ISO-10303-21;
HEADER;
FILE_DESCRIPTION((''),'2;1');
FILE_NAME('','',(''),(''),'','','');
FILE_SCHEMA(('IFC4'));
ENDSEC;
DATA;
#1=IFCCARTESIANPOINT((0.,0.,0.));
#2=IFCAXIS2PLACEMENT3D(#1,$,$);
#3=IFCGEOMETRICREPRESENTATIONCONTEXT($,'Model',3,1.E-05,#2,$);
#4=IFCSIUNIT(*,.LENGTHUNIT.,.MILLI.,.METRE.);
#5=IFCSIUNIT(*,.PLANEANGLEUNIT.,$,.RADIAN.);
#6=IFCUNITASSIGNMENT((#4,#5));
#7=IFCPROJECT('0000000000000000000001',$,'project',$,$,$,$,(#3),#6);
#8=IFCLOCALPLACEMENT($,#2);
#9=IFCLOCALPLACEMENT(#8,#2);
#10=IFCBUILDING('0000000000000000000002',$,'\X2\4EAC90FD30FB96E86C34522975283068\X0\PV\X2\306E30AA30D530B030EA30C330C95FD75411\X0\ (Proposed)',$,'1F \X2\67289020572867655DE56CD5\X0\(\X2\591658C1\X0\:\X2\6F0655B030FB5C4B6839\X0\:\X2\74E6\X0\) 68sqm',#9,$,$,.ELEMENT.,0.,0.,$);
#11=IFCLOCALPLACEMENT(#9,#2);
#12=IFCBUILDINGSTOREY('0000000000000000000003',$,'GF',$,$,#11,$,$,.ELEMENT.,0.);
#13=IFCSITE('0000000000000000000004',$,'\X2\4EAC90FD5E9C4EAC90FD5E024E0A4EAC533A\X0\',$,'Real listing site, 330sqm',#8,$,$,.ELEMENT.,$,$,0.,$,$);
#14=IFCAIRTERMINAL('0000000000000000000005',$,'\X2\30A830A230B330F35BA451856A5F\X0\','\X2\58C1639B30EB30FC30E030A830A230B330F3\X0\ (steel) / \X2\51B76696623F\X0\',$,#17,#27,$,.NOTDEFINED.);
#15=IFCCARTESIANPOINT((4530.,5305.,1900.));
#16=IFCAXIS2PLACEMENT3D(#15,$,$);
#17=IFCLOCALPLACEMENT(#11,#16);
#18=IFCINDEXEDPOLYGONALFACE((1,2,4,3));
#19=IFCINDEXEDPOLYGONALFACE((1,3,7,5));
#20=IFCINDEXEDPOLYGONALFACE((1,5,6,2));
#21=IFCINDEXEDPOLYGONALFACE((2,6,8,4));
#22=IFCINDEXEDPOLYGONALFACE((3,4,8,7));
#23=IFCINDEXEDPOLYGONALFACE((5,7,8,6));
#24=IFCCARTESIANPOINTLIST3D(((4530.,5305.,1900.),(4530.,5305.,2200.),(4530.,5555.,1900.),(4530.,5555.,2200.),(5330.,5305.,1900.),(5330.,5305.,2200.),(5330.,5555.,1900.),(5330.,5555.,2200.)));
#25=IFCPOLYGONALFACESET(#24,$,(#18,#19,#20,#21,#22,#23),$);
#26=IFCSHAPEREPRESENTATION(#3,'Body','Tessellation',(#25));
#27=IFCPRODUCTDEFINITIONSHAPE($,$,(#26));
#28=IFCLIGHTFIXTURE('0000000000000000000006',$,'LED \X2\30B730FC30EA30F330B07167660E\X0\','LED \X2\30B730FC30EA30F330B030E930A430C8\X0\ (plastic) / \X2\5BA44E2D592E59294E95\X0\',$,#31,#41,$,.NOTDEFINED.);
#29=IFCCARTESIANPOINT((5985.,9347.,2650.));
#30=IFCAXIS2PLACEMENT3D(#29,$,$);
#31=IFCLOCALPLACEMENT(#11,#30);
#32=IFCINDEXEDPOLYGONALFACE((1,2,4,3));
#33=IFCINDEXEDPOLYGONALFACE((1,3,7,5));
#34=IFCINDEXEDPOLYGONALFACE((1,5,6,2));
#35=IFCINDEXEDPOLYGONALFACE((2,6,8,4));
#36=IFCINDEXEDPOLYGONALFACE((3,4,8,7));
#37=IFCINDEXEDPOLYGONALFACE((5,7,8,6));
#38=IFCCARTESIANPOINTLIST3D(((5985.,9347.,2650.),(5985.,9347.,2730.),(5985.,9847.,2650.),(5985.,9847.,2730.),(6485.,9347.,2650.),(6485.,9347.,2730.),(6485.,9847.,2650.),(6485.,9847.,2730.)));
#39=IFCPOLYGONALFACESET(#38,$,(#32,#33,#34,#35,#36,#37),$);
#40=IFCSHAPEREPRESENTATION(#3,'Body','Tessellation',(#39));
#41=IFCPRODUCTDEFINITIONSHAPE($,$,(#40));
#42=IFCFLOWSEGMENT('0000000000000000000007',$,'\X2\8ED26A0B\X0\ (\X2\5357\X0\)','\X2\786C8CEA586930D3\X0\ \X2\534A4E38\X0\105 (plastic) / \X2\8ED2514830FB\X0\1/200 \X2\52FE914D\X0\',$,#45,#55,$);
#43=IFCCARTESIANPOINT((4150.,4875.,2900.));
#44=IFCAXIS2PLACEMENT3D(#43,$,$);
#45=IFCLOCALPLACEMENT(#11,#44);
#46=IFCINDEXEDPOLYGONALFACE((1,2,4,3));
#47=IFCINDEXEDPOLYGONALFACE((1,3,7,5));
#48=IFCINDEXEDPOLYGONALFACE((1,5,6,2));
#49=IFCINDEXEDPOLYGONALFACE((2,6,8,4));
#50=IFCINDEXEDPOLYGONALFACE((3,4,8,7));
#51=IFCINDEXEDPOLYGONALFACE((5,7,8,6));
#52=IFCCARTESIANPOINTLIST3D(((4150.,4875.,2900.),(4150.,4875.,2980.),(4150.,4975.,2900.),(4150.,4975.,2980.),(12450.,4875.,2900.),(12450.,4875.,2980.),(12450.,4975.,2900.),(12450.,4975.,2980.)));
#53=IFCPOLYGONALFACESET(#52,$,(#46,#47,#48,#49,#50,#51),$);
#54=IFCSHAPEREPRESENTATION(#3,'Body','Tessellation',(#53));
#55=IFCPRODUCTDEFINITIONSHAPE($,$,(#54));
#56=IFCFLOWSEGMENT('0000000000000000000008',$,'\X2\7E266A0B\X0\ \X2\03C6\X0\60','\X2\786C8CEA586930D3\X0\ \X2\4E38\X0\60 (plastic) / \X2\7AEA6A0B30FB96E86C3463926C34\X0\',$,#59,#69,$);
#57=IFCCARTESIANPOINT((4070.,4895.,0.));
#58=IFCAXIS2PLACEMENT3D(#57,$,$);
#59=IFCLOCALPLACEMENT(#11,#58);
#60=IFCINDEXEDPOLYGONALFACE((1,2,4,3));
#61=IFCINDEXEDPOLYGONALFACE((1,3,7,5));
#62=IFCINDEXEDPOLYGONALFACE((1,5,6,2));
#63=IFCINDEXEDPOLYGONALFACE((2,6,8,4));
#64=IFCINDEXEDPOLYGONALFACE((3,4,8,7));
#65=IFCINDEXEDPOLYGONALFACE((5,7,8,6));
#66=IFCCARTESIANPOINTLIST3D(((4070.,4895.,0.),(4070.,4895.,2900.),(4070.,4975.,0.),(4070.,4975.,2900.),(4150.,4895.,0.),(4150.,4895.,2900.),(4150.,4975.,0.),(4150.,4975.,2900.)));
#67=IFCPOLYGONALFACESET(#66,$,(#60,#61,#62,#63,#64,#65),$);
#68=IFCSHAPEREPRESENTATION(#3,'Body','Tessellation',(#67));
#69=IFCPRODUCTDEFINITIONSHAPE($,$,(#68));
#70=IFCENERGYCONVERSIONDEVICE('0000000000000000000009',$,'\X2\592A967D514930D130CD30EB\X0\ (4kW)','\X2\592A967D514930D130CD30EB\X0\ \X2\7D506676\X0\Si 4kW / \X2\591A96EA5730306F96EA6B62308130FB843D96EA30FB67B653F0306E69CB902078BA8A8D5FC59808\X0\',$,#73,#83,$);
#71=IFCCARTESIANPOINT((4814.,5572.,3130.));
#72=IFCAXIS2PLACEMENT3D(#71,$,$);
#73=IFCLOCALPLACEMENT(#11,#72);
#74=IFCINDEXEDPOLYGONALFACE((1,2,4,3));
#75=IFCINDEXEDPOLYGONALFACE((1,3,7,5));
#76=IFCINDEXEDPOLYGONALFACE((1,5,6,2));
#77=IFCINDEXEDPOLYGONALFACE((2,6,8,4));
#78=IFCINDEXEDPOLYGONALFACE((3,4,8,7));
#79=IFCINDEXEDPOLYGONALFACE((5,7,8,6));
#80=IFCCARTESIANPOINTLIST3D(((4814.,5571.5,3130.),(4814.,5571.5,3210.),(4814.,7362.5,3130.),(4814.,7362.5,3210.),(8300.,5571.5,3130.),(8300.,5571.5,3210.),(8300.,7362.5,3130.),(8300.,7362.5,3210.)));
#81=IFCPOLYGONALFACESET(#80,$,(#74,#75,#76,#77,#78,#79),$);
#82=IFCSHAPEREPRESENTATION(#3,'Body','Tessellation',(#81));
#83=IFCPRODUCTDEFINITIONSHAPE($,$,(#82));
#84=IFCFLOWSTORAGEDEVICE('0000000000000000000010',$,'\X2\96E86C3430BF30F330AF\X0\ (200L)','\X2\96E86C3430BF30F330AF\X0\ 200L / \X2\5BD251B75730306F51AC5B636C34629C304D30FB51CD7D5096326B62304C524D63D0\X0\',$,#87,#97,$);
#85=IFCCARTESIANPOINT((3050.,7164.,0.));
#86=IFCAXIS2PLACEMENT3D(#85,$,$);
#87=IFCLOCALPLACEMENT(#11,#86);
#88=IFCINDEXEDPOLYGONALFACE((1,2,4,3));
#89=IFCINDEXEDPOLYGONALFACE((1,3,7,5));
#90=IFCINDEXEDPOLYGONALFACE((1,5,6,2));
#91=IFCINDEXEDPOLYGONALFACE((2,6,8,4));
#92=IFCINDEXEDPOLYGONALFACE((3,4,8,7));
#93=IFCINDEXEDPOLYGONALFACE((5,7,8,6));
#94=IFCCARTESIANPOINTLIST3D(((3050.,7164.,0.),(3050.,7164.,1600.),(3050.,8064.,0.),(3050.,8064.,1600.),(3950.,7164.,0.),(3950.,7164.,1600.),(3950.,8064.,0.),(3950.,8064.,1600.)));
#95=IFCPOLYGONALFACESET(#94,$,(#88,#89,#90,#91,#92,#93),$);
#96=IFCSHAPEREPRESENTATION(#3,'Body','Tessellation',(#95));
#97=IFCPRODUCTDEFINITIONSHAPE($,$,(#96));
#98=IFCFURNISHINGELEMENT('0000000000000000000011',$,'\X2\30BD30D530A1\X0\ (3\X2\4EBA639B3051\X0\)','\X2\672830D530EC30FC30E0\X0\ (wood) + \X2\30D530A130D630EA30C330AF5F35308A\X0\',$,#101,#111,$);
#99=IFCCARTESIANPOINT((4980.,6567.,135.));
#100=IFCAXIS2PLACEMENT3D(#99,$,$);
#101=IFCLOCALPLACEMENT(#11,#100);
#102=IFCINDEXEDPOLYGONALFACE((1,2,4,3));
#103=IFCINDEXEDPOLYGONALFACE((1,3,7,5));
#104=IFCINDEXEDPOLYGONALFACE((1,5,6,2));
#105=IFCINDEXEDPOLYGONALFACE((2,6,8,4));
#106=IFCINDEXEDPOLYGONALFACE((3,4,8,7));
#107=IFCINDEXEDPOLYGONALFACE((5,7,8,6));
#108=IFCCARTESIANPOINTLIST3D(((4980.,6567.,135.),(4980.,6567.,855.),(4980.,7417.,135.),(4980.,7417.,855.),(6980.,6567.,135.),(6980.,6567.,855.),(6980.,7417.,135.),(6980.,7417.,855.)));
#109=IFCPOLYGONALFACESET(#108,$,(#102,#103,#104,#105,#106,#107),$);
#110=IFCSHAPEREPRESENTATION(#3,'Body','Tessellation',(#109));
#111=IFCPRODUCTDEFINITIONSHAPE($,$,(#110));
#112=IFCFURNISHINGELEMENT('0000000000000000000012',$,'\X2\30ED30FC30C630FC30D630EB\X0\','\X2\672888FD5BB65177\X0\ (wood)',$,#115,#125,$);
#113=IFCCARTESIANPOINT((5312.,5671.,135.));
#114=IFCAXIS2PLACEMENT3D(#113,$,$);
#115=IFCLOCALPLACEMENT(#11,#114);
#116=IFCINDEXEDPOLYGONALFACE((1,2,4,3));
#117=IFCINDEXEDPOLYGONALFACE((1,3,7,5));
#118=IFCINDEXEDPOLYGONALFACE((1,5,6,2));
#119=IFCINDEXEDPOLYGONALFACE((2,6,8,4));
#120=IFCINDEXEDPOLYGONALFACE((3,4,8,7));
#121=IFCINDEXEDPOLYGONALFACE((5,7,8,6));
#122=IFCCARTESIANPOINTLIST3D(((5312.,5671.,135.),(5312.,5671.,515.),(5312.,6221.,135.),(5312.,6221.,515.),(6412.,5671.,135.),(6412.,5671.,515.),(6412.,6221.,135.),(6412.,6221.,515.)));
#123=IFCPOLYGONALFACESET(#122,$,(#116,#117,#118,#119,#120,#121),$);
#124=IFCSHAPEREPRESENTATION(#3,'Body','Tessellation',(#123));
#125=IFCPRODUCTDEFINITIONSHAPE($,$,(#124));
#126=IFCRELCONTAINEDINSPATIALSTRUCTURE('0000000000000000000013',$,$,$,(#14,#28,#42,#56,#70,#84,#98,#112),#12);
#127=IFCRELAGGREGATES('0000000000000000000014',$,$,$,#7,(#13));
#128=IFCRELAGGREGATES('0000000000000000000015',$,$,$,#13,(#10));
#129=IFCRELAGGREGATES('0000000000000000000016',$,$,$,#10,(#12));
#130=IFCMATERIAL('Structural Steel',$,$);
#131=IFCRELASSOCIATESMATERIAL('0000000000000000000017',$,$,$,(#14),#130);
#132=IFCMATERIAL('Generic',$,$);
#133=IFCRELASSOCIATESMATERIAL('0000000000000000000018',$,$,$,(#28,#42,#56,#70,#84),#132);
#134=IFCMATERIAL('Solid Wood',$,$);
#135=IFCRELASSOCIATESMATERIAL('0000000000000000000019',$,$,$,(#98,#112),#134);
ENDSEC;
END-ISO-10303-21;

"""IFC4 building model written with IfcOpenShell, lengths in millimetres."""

from ifc_helpers import new_model, si_unit, frame, frame_2d, origin, place, context, project, spatial, rectangle, extrude, material, element, save


model = new_model("IFC4")

# Units and contexts
model_context = context("Model", 3, precision=1e-05, world=origin())
ifc_project = project(units=[si_unit("LENGTHUNIT", "METRE", prefix="MILLI"), si_unit("PLANEANGLEUNIT", "RADIAN")], contexts=[model_context])

# Site, building, storey
site_placement = place(None, origin())
site = spatial("IfcSite", under=ifc_project, at=site_placement, Name="京都府京都市上京区", ObjectType="Real listing site, 330sqm", CompositionType="ELEMENT", RefElevation=0.0)
building_placement = place(site_placement, origin())
building = spatial("IfcBuilding", under=site, at=building_placement, Name="京都・雨水利用とPVのオフグリッド志向 (Proposed)", ObjectType="1F 木造在来工法(外壁:漆喰・屋根:瓦) 68sqm", CompositionType="ELEMENT", ElevationOfRefHeight=0.0, ElevationOfTerrain=0.0)
storey_placement = place(building_placement, origin())
storey = spatial("IfcBuildingStorey", under=building, at=storey_placement, Name="GF", CompositionType="ELEMENT", Elevation=0.0)

# Shared definitions
ifc_material_1 = material(Name="Solid Wood")

# Shared definitions
ifc_material_2 = material(Name="Structural Steel")

# Shared definitions
ifc_material_3 = material(Name="Generic")

# Air terminal
air_terminal_placement = place(storey_placement, frame((4530.0, 5305.0, 1900.0)))
element("IfcAirTerminal", 1, at=air_terminal_placement, inside=storey, material=ifc_material_2, Name="エアコン室内機", Description="壁掛ルームエアコン (steel) / 冷暖房", PredefinedType="NOTDEFINED", context=model_context, shape_type="SweptSolid", body=[
    extrude(rectangle(XDim=800.0, YDim=250.0, at=frame_2d((400.0, 125.0))), frame((4530.0, 5305.0, 1900.0)), (0.0, 0.0, 1.0), 300.0),
])

# Light fixture
light_fixture_placement = place(storey_placement, frame((5985.0, 9347.0, 2650.0)))
element("IfcLightFixture", 2, at=light_fixture_placement, inside=storey, material=ifc_material_3, Name="LED シーリング照明", Description="LED シーリングライト (plastic) / 室中央天井", PredefinedType="NOTDEFINED", context=model_context, shape_type="SweptSolid", body=[
    extrude(rectangle(XDim=500.0, YDim=500.0, at=frame_2d((250.0, 250.0))), frame((5985.0, 9347.0, 2650.0)), (0.0, 0.0, 1.0), 80.0),
])

# Flow segments
flow_segment_1_placement = place(storey_placement, frame((4150.0, 4875.0, 2900.0)))
element("IfcFlowSegment", 3, at=flow_segment_1_placement, inside=storey, material=ifc_material_3, Name="軒樋 (南)", Description="硬質塩ビ 半丸105 (plastic) / 軒先・1/200 勾配", context=model_context, shape_type="SweptSolid", body=[
    extrude(rectangle(XDim=8300.0, YDim=100.0, at=frame_2d((4150.0, 50.0))), frame((4150.0, 4875.0, 2900.0)), (0.0, 0.0, 1.0), 80.0),
])
flow_segment_2_placement = place(storey_placement, frame((4070.0, 4895.0, 0.0)))
element("IfcFlowSegment", 4, at=flow_segment_2_placement, inside=storey, material=ifc_material_3, Name="縦樋 φ60", Description="硬質塩ビ 丸60 (plastic) / 竪樋・雨水排水", context=model_context, shape_type="SweptSolid", body=[
    extrude(rectangle(XDim=80.0, YDim=80.0, at=frame_2d((40.0, 40.0))), frame((4070.0, 4895.0, 0.0)), (0.0, 0.0, 1.0), 2900.0),
])

# Energy conversion device
energy_conversion_device_placement = place(storey_placement, frame((4814.0, 5572.0, 3130.0)))
element("IfcEnergyConversionDevice", 5, at=energy_conversion_device_placement, inside=storey, material=ifc_material_3, Name="太陽光パネル (4kW)", Description="太陽光パネル 結晶Si 4kW / 多雪地は雪止め・落雪・架台の構造確認必須", context=model_context, shape_type="SweptSolid", body=[
    extrude(rectangle(XDim=3486.0, YDim=1791.0, at=frame_2d((1743.0, 895.0))), frame((4814.0, 5572.0, 3130.0)), (0.0, 0.0, 1.0), 80.0),
])

# Flow storage device
flow_storage_device_1_placement = place(storey_placement, frame((3050.0, 7164.0, 0.0)))
element("IfcFlowStorageDevice", 6, at=flow_storage_device_1_placement, inside=storey, material=ifc_material_3, Name="雨水タンク (200L)", Description="雨水タンク 200L / 寒冷地は冬季水抜き・凍結防止が前提", context=model_context, shape_type="SweptSolid", body=[
    extrude(rectangle(XDim=900.0, YDim=900.0, at=frame_2d((450.0, 450.0))), frame((3050.0, 7164.0, 0.0)), (0.0, 0.0, 1.0), 1600.0),
])

# Furnishing elements
furnishing_1_placement = place(storey_placement, frame((4980.0, 6567.0, 135.0)))
element("IfcFurnishingElement", 7, at=furnishing_1_placement, inside=storey, material=ifc_material_1, Name="ソファ (3人掛け)", Description="木フレーム (wood) + ファブリック張り", context=model_context, shape_type="SweptSolid", body=[
    extrude(rectangle(XDim=2000.0, YDim=850.0, at=frame_2d((1000.0, 425.0))), frame((4980.0, 6567.0, 135.0)), (0.0, 0.0, 1.0), 720.0),
])
furnishing_2_placement = place(storey_placement, frame((5312.0, 5671.0, 135.0)))
element("IfcFurnishingElement", 8, at=furnishing_2_placement, inside=storey, material=ifc_material_1, Name="ローテーブル", Description="木製家具 (wood)", context=model_context, shape_type="SweptSolid", body=[
    extrude(rectangle(XDim=1100.0, YDim=550.0, at=frame_2d((550.0, 275.0))), frame((5312.0, 5671.0, 135.0)), (0.0, 0.0, 1.0), 380.0),
])

save(model, "model.ifc")
